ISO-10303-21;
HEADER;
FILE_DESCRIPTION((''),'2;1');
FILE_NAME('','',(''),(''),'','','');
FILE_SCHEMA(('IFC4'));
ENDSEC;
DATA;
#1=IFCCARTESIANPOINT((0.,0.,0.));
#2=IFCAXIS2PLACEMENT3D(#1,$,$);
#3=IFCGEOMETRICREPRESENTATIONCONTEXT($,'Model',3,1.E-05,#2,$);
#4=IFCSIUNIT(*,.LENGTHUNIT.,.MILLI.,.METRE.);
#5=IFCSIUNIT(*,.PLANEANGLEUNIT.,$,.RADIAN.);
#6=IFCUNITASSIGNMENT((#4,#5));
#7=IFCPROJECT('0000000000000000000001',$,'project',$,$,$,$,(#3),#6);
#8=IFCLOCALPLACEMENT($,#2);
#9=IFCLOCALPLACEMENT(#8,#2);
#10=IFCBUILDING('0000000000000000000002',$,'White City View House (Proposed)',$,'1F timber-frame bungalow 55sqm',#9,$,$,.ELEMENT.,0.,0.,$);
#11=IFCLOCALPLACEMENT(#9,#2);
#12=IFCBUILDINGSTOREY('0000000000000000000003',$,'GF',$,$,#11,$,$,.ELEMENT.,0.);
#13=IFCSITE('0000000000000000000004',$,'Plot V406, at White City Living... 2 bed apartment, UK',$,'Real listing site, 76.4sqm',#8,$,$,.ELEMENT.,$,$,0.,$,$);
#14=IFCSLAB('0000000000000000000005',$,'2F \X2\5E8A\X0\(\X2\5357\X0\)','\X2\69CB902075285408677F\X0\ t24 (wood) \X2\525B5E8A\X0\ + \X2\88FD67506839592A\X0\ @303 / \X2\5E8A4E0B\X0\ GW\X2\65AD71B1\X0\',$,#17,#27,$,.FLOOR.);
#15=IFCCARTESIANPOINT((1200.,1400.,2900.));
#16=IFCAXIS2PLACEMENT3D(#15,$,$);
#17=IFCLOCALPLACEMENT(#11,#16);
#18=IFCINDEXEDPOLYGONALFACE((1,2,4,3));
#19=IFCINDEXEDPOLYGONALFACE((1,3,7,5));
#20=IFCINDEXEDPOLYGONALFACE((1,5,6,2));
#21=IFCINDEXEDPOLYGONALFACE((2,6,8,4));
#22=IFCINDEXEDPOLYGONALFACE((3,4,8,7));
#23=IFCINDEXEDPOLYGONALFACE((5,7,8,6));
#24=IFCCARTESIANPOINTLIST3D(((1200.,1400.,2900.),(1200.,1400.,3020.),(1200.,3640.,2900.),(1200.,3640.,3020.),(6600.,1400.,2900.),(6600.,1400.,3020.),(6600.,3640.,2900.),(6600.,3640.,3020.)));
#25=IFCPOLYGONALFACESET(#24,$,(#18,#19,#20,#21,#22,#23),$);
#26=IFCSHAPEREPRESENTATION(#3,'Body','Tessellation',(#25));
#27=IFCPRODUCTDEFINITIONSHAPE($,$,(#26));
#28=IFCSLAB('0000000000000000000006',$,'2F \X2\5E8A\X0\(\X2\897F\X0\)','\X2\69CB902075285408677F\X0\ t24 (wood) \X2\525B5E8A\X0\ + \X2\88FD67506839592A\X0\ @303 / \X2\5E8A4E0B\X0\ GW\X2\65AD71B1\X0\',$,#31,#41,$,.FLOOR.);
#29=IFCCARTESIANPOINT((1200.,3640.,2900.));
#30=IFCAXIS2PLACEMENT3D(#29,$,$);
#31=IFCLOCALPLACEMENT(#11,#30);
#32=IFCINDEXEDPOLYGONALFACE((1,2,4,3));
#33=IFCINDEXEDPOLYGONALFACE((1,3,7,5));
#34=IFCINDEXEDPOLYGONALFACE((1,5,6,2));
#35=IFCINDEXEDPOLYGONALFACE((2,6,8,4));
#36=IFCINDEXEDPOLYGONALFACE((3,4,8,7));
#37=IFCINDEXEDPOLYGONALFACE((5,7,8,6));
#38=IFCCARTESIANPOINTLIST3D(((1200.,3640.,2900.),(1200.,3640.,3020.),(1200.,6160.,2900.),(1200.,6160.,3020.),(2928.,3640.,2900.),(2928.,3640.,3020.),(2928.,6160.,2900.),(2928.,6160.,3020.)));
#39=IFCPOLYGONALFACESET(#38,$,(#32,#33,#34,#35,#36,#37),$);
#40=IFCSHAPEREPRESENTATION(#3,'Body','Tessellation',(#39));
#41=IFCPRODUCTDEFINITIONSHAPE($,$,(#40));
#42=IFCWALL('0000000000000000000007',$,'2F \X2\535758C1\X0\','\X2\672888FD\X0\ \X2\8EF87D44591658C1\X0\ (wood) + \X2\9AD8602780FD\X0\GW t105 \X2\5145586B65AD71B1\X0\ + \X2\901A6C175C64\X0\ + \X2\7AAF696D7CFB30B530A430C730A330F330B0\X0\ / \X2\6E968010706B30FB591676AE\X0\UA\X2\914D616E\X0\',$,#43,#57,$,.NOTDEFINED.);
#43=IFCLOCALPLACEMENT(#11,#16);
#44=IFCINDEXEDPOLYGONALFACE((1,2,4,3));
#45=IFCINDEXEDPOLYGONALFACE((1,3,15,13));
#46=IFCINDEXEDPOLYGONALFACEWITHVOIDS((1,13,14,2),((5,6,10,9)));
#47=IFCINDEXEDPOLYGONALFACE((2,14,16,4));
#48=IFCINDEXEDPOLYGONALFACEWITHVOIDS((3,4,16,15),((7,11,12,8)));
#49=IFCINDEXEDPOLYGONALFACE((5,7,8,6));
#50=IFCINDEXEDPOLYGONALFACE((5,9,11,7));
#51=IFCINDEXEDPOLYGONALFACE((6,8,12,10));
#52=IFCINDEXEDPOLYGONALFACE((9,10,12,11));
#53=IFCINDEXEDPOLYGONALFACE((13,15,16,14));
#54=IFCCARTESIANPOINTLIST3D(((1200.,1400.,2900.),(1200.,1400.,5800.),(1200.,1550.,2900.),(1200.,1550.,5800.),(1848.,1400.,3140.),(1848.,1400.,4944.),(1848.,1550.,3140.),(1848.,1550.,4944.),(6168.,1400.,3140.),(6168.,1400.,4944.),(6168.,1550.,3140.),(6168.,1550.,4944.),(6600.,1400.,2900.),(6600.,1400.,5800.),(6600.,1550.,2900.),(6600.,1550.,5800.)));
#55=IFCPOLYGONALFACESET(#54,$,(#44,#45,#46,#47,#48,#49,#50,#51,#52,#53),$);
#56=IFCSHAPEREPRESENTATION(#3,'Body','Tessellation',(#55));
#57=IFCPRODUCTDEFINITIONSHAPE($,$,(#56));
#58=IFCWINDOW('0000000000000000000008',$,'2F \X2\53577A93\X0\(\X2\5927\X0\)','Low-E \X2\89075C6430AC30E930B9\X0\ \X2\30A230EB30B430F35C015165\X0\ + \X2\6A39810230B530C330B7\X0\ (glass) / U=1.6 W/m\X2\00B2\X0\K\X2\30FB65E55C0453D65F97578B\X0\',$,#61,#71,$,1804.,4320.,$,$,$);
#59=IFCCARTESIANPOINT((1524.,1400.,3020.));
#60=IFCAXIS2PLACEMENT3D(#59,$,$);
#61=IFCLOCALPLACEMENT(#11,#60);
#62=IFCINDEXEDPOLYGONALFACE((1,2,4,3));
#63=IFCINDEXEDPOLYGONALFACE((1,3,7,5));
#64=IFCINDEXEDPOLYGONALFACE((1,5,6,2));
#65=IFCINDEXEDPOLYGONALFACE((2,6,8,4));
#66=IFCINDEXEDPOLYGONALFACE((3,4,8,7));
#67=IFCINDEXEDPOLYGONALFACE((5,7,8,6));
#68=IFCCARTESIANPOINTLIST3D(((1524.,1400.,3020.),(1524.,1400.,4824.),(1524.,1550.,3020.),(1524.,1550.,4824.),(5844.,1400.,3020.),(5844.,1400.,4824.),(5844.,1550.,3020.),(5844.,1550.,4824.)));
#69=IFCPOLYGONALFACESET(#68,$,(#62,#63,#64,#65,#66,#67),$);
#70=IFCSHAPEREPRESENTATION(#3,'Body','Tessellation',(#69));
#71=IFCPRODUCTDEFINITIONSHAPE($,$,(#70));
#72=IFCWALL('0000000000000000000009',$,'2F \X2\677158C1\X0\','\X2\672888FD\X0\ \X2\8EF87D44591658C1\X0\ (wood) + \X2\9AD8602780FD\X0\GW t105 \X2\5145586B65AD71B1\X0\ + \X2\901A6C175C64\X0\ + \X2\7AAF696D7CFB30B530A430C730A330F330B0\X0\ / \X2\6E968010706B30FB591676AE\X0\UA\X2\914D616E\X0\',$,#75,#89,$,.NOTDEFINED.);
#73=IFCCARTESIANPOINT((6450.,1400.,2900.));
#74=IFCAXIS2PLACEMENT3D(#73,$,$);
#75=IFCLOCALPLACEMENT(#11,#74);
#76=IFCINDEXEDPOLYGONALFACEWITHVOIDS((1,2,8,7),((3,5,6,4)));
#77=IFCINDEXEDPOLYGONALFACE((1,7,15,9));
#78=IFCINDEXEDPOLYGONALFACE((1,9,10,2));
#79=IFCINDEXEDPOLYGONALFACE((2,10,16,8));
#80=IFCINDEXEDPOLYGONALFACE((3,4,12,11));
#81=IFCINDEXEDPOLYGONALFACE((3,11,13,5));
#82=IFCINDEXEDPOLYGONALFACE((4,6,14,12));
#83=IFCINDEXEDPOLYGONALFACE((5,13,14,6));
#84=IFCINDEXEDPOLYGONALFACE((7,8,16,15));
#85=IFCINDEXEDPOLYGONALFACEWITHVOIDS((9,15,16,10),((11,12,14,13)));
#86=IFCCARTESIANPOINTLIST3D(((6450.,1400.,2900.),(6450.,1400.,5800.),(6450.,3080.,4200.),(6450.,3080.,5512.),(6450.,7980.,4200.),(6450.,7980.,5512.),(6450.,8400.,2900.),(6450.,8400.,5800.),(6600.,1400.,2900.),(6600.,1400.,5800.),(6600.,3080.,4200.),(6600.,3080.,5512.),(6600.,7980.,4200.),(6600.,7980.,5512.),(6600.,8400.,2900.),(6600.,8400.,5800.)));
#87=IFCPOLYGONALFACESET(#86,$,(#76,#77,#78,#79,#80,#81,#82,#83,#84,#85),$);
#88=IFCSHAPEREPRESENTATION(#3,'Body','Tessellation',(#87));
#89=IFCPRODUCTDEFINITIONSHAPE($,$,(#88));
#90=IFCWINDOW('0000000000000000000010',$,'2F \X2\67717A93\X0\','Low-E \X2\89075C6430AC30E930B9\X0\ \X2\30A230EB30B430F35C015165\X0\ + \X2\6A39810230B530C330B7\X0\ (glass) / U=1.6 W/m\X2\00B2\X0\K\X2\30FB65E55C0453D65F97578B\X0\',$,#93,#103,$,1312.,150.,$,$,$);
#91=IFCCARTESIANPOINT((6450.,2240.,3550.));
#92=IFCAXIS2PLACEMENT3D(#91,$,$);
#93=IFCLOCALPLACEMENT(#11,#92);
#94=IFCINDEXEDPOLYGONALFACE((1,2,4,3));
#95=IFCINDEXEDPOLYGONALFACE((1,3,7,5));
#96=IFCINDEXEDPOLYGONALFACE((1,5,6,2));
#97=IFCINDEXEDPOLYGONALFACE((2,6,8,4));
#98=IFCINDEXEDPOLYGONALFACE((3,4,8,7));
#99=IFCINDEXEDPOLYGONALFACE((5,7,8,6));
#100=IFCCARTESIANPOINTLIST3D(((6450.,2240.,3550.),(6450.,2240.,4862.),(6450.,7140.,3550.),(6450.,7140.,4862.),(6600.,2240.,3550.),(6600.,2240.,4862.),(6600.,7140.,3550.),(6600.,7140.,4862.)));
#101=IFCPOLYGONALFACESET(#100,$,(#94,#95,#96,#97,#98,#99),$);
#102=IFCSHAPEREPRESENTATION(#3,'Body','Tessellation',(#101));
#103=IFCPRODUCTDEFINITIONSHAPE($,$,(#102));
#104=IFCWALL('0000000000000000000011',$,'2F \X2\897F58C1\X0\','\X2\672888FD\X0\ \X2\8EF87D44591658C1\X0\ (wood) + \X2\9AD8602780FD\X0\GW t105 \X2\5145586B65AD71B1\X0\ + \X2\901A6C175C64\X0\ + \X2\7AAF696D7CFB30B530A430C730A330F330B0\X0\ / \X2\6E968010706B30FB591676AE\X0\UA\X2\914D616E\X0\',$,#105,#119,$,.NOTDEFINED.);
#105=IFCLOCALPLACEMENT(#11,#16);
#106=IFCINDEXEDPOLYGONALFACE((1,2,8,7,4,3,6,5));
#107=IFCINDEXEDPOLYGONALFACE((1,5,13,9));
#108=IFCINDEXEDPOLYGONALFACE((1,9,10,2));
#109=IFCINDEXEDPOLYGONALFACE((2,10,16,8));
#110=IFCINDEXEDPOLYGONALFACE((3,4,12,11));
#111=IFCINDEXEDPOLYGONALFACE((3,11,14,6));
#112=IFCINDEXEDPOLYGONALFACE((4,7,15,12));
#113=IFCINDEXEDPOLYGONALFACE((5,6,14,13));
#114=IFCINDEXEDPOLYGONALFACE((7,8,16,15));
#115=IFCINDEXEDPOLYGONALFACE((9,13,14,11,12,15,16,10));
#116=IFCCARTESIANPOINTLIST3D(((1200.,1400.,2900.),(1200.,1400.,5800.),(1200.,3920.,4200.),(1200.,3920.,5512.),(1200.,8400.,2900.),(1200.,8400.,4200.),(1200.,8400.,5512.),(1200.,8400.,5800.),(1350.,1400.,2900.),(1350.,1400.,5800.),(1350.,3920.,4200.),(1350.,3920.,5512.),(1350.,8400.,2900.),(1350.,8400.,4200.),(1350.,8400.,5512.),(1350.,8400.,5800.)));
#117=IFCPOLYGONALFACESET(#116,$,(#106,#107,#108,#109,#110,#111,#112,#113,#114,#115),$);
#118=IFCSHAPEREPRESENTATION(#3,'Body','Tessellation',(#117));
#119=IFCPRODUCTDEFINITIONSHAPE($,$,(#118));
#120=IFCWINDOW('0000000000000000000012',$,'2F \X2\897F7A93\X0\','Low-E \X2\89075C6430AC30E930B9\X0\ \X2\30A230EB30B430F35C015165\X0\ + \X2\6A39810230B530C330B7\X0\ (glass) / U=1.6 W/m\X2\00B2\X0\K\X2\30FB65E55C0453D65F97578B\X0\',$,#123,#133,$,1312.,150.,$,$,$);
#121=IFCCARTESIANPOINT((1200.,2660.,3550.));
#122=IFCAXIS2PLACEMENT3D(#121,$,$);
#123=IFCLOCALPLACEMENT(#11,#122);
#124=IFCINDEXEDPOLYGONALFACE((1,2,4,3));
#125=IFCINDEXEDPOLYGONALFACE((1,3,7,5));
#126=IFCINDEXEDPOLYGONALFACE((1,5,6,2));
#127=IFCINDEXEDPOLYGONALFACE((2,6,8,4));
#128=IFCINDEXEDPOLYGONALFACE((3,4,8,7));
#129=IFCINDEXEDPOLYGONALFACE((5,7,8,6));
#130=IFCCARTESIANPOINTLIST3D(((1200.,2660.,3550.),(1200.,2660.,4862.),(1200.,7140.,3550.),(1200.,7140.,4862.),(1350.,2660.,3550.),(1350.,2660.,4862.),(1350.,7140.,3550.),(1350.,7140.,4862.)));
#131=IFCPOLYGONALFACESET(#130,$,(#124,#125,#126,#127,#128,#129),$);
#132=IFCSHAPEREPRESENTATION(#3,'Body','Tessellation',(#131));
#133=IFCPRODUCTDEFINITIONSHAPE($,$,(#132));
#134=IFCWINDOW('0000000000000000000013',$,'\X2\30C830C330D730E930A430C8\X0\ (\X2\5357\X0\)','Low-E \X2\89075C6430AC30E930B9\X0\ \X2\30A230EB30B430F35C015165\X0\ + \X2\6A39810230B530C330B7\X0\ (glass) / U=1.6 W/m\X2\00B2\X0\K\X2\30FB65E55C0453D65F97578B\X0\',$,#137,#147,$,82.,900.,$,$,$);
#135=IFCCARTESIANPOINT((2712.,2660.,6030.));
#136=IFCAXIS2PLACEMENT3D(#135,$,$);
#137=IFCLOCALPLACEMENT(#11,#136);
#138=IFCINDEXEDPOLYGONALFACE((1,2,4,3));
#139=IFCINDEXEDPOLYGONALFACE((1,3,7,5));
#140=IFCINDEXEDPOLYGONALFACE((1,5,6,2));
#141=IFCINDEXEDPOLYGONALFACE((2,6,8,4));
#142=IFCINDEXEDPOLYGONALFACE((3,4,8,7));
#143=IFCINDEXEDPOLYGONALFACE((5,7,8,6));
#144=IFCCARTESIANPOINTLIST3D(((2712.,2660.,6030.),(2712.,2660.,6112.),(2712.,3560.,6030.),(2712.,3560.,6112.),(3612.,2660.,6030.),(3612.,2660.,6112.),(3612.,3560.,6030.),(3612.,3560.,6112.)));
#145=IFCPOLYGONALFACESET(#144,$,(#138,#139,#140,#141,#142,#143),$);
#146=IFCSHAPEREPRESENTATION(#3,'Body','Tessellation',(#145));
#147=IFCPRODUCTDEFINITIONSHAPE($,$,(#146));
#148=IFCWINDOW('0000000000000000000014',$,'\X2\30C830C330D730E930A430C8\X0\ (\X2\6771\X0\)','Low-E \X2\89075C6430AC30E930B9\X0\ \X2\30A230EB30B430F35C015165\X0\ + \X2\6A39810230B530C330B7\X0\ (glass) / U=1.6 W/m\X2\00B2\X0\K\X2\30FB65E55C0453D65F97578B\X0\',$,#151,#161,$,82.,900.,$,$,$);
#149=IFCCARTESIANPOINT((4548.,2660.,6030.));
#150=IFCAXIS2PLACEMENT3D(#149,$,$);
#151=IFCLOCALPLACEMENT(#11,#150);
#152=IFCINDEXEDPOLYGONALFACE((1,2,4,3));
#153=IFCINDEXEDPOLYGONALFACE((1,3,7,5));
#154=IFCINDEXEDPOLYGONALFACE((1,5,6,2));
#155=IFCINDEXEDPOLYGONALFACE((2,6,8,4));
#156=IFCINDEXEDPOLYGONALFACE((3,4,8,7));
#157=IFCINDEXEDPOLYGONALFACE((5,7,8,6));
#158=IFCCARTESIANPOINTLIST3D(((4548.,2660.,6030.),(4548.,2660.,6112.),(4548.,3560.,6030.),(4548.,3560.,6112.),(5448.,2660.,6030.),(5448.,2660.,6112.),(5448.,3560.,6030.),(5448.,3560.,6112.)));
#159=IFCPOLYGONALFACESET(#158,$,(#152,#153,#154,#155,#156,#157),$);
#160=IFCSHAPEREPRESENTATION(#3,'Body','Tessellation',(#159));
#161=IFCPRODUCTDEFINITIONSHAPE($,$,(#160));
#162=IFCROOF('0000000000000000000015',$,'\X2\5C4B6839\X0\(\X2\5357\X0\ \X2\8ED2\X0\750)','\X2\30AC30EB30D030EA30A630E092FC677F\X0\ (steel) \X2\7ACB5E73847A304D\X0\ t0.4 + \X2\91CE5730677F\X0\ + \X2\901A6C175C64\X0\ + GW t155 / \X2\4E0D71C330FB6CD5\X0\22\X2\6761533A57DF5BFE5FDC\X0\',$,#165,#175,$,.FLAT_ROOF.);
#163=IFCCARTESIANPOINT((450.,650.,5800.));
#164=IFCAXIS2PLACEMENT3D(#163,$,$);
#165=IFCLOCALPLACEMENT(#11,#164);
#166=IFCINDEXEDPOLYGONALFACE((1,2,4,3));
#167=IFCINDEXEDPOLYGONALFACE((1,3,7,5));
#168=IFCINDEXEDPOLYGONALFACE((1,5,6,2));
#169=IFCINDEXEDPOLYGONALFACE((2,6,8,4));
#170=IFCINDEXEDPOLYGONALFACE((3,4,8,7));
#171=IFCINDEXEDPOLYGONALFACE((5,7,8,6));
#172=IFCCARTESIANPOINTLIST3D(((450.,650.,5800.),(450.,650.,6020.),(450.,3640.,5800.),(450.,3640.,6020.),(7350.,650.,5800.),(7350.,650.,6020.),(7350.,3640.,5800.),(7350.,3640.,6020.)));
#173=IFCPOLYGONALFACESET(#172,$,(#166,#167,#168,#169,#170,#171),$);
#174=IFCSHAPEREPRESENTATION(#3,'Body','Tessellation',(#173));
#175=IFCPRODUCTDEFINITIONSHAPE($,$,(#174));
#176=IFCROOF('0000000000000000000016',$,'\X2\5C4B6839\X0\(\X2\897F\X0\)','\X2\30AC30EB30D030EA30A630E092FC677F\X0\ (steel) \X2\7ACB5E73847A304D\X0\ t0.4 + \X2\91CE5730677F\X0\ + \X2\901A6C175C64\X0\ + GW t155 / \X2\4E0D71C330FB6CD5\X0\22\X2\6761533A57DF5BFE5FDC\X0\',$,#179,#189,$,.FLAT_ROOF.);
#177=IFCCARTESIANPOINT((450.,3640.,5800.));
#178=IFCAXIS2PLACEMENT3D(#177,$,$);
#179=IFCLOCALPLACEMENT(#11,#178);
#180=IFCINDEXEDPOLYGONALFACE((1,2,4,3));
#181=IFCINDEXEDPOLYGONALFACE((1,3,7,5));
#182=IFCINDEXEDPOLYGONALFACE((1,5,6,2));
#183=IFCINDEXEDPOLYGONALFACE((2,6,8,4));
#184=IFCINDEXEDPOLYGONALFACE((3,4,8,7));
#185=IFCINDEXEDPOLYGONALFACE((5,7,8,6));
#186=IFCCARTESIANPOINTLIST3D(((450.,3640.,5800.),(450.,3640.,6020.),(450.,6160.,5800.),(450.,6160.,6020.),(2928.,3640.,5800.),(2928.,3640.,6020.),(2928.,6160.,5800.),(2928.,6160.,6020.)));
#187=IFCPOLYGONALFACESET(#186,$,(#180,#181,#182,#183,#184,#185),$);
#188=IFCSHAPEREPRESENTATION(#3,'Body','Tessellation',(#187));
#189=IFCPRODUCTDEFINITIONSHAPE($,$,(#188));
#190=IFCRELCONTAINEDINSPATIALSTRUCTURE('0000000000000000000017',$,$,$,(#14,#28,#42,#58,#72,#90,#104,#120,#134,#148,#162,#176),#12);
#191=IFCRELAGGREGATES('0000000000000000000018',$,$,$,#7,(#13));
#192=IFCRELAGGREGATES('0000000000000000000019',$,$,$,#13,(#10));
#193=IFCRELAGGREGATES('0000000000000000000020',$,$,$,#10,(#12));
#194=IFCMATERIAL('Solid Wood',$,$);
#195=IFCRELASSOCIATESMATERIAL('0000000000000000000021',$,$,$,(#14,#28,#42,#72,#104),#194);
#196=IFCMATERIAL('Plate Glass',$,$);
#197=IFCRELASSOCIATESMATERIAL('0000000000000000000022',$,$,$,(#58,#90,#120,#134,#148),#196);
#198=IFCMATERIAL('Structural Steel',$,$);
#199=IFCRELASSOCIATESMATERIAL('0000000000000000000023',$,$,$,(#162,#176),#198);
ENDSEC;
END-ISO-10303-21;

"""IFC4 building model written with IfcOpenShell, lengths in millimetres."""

from ifc_helpers import new_model, si_unit, frame, frame_2d, origin, place, context, project, spatial, rectangle, extrude, material, element, fill, save


model = new_model("IFC4")

# Units and contexts
model_context = context("Model", 3, precision=1e-05, world=origin())
ifc_project = project(units=[si_unit("LENGTHUNIT", "METRE", prefix="MILLI"), si_unit("PLANEANGLEUNIT", "RADIAN")], contexts=[model_context])

# Site, building, storey
site_placement = place(None, origin())
site = spatial("IfcSite", under=ifc_project, at=site_placement, Name="Plot V406, at White City Living... 2 bed apartment, UK", ObjectType="Real listing site, 76.4sqm", CompositionType="ELEMENT", RefElevation=0.0)
building_placement = place(site_placement, origin())
building = spatial("IfcBuilding", under=site, at=building_placement, Name="White City View House (Proposed)", ObjectType="1F timber-frame bungalow 55sqm", CompositionType="ELEMENT", ElevationOfRefHeight=0.0, ElevationOfTerrain=0.0)
storey_placement = place(building_placement, origin())
storey = spatial("IfcBuildingStorey", under=building, at=storey_placement, Name="GF", CompositionType="ELEMENT", Elevation=0.0)

# Slabs
ifc_material_1 = material(Name="Solid Wood")
slab_1_placement = place(storey_placement, frame((1200.0, 1400.0, 2900.0)))
element("IfcSlab", 1, at=slab_1_placement, inside=storey, material=ifc_material_1, Name="2F 床(南)", Description="構造用合板 t24 (wood) 剛床 + 製材根太 @303 / 床下 GW断熱", PredefinedType="FLOOR", context=model_context, shape_type="SweptSolid", body=[
    extrude(rectangle(XDim=5400.0, YDim=2240.0, at=frame_2d((2700.0, 1120.0))), frame((1200.0, 1400.0, 2900.0)), (0.0, 0.0, 1.0), 120.0),
])
slab_2_placement = place(storey_placement, frame((1200.0, 3640.0, 2900.0)))
element("IfcSlab", 2, at=slab_2_placement, inside=storey, material=ifc_material_1, Name="2F 床(西)", Description="構造用合板 t24 (wood) 剛床 + 製材根太 @303 / 床下 GW断熱", PredefinedType="FLOOR", context=model_context, shape_type="SweptSolid", body=[
    extrude(rectangle(XDim=1728.0, YDim=2520.0, at=frame_2d((864.0, 1260.0))), frame((1200.0, 3640.0, 2900.0)), (0.0, 0.0, 1.0), 120.0),
])

# Walls, openings, windows
wall_1_placement = place(storey_placement, frame((1200.0, 1400.0, 2900.0)))
wall_1 = element("IfcWall", 3, at=wall_1_placement, inside=storey, material=ifc_material_1, Name="2F 南壁", Description="木製 軸組外壁 (wood) + 高性能GW t105 充填断熱 + 通気層 + 窯業系サイディング / 準耐火・外皮UA配慮", PredefinedType="NOTDEFINED", context=model_context, shape_type="SweptSolid", body=[
    extrude(rectangle(XDim=5400.0, YDim=150.0, at=frame_2d((2700.0, 75.0))), frame((1200.0, 1400.0, 2900.0)), (0.0, 0.0, 1.0), 2900.0),
])
opening_1_placement = place(storey_placement, frame((1524.0, 1400.0, 3020.0)))
opening_1 = element("IfcOpeningElement", 4, at=opening_1_placement, cuts=wall_1, PredefinedType="NOTDEFINED", context=model_context, shape_type="SweptSolid", body=[
    extrude(rectangle(XDim=4320.0, YDim=150.0, at=frame_2d((2160.0, 75.0))), frame((1524.0, 1400.0, 3020.0)), (0.0, 0.0, 1.0), 1804.0),
])
ifc_material_2 = material(Name="Plate Glass")
window_1_placement = place(storey_placement, frame((1524.0, 1400.0, 3020.0)))
window_1 = element("IfcWindow", 5, at=window_1_placement, inside=storey, material=ifc_material_2, Name="2F 南窓(大)", Description="Low-E 複層ガラス アルゴン封入 + 樹脂サッシ (glass) / U=1.6 W/m²K・日射取得型", OverallHeight=1804.0, OverallWidth=4320.0, context=model_context, shape_type="SweptSolid", body=[
    extrude(rectangle(XDim=4320.0, YDim=150.0, at=frame_2d((2160.0, 75.0))), frame((1524.0, 1400.0, 3020.0)), (0.0, 0.0, 1.0), 1804.0),
])
fill(opening_1, window_1)
wall_2_placement = place(storey_placement, frame((6450.0, 1400.0, 2900.0)))
wall_2 = element("IfcWall", 6, at=wall_2_placement, inside=storey, material=ifc_material_1, Name="2F 東壁", Description="木製 軸組外壁 (wood) + 高性能GW t105 充填断熱 + 通気層 + 窯業系サイディング / 準耐火・外皮UA配慮", PredefinedType="NOTDEFINED", context=model_context, shape_type="SweptSolid", body=[
    extrude(rectangle(XDim=150.0, YDim=7000.0, at=frame_2d((75.0, 3500.0))), frame((6450.0, 1400.0, 2900.0)), (0.0, 0.0, 1.0), 2900.0),
])
opening_2_placement = place(storey_placement, frame((6450.0, 2240.0, 3550.0)))
opening_2 = element("IfcOpeningElement", 7, at=opening_2_placement, cuts=wall_2, PredefinedType="NOTDEFINED", context=model_context, shape_type="SweptSolid", body=[
    extrude(rectangle(XDim=150.0, YDim=4900.0, at=frame_2d((75.0, 2450.0))), frame((6450.0, 2240.0, 3550.0)), (0.0, 0.0, 1.0), 1312.0),
])
window_2_placement = place(storey_placement, frame((6450.0, 2240.0, 3550.0)))
window_2 = element("IfcWindow", 8, at=window_2_placement, inside=storey, material=ifc_material_2, Name="2F 東窓", Description="Low-E 複層ガラス アルゴン封入 + 樹脂サッシ (glass) / U=1.6 W/m²K・日射取得型", OverallHeight=1312.0, OverallWidth=150.0, context=model_context, shape_type="SweptSolid", body=[
    extrude(rectangle(XDim=150.0, YDim=4900.0, at=frame_2d((75.0, 2450.0))), frame((6450.0, 2240.0, 3550.0)), (0.0, 0.0, 1.0), 1312.0),
])
fill(opening_2, window_2)
wall_3_placement = place(storey_placement, frame((1200.0, 1400.0, 2900.0)))
wall_3 = element("IfcWall", 9, at=wall_3_placement, inside=storey, material=ifc_material_1, Name="2F 西壁", Description="木製 軸組外壁 (wood) + 高性能GW t105 充填断熱 + 通気層 + 窯業系サイディング / 準耐火・外皮UA配慮", PredefinedType="NOTDEFINED", context=model_context, shape_type="SweptSolid", body=[
    extrude(rectangle(XDim=150.0, YDim=7000.0, at=frame_2d((75.0, 3500.0))), frame((1200.0, 1400.0, 2900.0)), (0.0, 0.0, 1.0), 2900.0),
])
opening_3_placement = place(storey_placement, frame((1200.0, 2660.0, 3550.0)))
opening_3 = element("IfcOpeningElement", 10, at=opening_3_placement, cuts=wall_3, PredefinedType="NOTDEFINED", context=model_context, shape_type="SweptSolid", body=[
    extrude(rectangle(XDim=150.0, YDim=4480.0, at=frame_2d((75.0, 2240.0))), frame((1200.0, 2660.0, 3550.0)), (0.0, 0.0, 1.0), 1312.0),
])
window_3_placement = place(storey_placement, frame((1200.0, 2660.0, 3550.0)))
window_3 = element("IfcWindow", 11, at=window_3_placement, inside=storey, material=ifc_material_2, Name="2F 西窓", Description="Low-E 複層ガラス アルゴン封入 + 樹脂サッシ (glass) / U=1.6 W/m²K・日射取得型", OverallHeight=1312.0, OverallWidth=150.0, context=model_context, shape_type="SweptSolid", body=[
    extrude(rectangle(XDim=150.0, YDim=4480.0, at=frame_2d((75.0, 2240.0))), frame((1200.0, 2660.0, 3550.0)), (0.0, 0.0, 1.0), 1312.0),
])
fill(opening_3, window_3)

# Windows
window_4_placement = place(storey_placement, frame((2712.0, 2660.0, 6030.0)))
element("IfcWindow", 12, at=window_4_placement, inside=storey, material=ifc_material_2, Name="トップライト (南)", Description="Low-E 複層ガラス アルゴン封入 + 樹脂サッシ (glass) / U=1.6 W/m²K・日射取得型", OverallHeight=82.0, OverallWidth=900.0, context=model_context, shape_type="SweptSolid", body=[
    extrude(rectangle(XDim=900.0, YDim=900.0, at=frame_2d((450.0, 450.0))), frame((2712.0, 2660.0, 6030.0)), (0.0, 0.0, 1.0), 82.0),
])
window_5_placement = place(storey_placement, frame((4548.0, 2660.0, 6030.0)))
element("IfcWindow", 13, at=window_5_placement, inside=storey, material=ifc_material_2, Name="トップライト (東)", Description="Low-E 複層ガラス アルゴン封入 + 樹脂サッシ (glass) / U=1.6 W/m²K・日射取得型", OverallHeight=82.0, OverallWidth=900.0, context=model_context, shape_type="SweptSolid", body=[
    extrude(rectangle(XDim=900.0, YDim=900.0, at=frame_2d((450.0, 450.0))), frame((4548.0, 2660.0, 6030.0)), (0.0, 0.0, 1.0), 82.0),
])

# Roofs
ifc_material_3 = material(Name="Structural Steel")
roof_1_placement = place(storey_placement, frame((450.0, 650.0, 5800.0)))
element("IfcRoof", 14, at=roof_1_placement, inside=storey, material=ifc_material_3, Name="屋根(南 軒750)", Description="ガルバリウム鋼板 (steel) 立平葺き t0.4 + 野地板 + 通気層 + GW t155 / 不燃・法22条区域対応", PredefinedType="FLAT_ROOF", context=model_context, shape_type="SweptSolid", body=[
    extrude(rectangle(XDim=6900.0, YDim=2990.0, at=frame_2d((3450.0, 1495.0))), frame((450.0, 650.0, 5800.0)), (0.0, 0.0, 1.0), 220.0),
])
roof_2_placement = place(storey_placement, frame((450.0, 3640.0, 5800.0)))
element("IfcRoof", 15, at=roof_2_placement, inside=storey, material=ifc_material_3, Name="屋根(西)", Description="ガルバリウム鋼板 (steel) 立平葺き t0.4 + 野地板 + 通気層 + GW t155 / 不燃・法22条区域対応", PredefinedType="FLAT_ROOF", context=model_context, shape_type="SweptSolid", body=[
    extrude(rectangle(XDim=2478.0, YDim=2520.0, at=frame_2d((1239.0, 1260.0))), frame((450.0, 3640.0, 5800.0)), (0.0, 0.0, 1.0), 220.0),
])

save(model, "model.ifc")
